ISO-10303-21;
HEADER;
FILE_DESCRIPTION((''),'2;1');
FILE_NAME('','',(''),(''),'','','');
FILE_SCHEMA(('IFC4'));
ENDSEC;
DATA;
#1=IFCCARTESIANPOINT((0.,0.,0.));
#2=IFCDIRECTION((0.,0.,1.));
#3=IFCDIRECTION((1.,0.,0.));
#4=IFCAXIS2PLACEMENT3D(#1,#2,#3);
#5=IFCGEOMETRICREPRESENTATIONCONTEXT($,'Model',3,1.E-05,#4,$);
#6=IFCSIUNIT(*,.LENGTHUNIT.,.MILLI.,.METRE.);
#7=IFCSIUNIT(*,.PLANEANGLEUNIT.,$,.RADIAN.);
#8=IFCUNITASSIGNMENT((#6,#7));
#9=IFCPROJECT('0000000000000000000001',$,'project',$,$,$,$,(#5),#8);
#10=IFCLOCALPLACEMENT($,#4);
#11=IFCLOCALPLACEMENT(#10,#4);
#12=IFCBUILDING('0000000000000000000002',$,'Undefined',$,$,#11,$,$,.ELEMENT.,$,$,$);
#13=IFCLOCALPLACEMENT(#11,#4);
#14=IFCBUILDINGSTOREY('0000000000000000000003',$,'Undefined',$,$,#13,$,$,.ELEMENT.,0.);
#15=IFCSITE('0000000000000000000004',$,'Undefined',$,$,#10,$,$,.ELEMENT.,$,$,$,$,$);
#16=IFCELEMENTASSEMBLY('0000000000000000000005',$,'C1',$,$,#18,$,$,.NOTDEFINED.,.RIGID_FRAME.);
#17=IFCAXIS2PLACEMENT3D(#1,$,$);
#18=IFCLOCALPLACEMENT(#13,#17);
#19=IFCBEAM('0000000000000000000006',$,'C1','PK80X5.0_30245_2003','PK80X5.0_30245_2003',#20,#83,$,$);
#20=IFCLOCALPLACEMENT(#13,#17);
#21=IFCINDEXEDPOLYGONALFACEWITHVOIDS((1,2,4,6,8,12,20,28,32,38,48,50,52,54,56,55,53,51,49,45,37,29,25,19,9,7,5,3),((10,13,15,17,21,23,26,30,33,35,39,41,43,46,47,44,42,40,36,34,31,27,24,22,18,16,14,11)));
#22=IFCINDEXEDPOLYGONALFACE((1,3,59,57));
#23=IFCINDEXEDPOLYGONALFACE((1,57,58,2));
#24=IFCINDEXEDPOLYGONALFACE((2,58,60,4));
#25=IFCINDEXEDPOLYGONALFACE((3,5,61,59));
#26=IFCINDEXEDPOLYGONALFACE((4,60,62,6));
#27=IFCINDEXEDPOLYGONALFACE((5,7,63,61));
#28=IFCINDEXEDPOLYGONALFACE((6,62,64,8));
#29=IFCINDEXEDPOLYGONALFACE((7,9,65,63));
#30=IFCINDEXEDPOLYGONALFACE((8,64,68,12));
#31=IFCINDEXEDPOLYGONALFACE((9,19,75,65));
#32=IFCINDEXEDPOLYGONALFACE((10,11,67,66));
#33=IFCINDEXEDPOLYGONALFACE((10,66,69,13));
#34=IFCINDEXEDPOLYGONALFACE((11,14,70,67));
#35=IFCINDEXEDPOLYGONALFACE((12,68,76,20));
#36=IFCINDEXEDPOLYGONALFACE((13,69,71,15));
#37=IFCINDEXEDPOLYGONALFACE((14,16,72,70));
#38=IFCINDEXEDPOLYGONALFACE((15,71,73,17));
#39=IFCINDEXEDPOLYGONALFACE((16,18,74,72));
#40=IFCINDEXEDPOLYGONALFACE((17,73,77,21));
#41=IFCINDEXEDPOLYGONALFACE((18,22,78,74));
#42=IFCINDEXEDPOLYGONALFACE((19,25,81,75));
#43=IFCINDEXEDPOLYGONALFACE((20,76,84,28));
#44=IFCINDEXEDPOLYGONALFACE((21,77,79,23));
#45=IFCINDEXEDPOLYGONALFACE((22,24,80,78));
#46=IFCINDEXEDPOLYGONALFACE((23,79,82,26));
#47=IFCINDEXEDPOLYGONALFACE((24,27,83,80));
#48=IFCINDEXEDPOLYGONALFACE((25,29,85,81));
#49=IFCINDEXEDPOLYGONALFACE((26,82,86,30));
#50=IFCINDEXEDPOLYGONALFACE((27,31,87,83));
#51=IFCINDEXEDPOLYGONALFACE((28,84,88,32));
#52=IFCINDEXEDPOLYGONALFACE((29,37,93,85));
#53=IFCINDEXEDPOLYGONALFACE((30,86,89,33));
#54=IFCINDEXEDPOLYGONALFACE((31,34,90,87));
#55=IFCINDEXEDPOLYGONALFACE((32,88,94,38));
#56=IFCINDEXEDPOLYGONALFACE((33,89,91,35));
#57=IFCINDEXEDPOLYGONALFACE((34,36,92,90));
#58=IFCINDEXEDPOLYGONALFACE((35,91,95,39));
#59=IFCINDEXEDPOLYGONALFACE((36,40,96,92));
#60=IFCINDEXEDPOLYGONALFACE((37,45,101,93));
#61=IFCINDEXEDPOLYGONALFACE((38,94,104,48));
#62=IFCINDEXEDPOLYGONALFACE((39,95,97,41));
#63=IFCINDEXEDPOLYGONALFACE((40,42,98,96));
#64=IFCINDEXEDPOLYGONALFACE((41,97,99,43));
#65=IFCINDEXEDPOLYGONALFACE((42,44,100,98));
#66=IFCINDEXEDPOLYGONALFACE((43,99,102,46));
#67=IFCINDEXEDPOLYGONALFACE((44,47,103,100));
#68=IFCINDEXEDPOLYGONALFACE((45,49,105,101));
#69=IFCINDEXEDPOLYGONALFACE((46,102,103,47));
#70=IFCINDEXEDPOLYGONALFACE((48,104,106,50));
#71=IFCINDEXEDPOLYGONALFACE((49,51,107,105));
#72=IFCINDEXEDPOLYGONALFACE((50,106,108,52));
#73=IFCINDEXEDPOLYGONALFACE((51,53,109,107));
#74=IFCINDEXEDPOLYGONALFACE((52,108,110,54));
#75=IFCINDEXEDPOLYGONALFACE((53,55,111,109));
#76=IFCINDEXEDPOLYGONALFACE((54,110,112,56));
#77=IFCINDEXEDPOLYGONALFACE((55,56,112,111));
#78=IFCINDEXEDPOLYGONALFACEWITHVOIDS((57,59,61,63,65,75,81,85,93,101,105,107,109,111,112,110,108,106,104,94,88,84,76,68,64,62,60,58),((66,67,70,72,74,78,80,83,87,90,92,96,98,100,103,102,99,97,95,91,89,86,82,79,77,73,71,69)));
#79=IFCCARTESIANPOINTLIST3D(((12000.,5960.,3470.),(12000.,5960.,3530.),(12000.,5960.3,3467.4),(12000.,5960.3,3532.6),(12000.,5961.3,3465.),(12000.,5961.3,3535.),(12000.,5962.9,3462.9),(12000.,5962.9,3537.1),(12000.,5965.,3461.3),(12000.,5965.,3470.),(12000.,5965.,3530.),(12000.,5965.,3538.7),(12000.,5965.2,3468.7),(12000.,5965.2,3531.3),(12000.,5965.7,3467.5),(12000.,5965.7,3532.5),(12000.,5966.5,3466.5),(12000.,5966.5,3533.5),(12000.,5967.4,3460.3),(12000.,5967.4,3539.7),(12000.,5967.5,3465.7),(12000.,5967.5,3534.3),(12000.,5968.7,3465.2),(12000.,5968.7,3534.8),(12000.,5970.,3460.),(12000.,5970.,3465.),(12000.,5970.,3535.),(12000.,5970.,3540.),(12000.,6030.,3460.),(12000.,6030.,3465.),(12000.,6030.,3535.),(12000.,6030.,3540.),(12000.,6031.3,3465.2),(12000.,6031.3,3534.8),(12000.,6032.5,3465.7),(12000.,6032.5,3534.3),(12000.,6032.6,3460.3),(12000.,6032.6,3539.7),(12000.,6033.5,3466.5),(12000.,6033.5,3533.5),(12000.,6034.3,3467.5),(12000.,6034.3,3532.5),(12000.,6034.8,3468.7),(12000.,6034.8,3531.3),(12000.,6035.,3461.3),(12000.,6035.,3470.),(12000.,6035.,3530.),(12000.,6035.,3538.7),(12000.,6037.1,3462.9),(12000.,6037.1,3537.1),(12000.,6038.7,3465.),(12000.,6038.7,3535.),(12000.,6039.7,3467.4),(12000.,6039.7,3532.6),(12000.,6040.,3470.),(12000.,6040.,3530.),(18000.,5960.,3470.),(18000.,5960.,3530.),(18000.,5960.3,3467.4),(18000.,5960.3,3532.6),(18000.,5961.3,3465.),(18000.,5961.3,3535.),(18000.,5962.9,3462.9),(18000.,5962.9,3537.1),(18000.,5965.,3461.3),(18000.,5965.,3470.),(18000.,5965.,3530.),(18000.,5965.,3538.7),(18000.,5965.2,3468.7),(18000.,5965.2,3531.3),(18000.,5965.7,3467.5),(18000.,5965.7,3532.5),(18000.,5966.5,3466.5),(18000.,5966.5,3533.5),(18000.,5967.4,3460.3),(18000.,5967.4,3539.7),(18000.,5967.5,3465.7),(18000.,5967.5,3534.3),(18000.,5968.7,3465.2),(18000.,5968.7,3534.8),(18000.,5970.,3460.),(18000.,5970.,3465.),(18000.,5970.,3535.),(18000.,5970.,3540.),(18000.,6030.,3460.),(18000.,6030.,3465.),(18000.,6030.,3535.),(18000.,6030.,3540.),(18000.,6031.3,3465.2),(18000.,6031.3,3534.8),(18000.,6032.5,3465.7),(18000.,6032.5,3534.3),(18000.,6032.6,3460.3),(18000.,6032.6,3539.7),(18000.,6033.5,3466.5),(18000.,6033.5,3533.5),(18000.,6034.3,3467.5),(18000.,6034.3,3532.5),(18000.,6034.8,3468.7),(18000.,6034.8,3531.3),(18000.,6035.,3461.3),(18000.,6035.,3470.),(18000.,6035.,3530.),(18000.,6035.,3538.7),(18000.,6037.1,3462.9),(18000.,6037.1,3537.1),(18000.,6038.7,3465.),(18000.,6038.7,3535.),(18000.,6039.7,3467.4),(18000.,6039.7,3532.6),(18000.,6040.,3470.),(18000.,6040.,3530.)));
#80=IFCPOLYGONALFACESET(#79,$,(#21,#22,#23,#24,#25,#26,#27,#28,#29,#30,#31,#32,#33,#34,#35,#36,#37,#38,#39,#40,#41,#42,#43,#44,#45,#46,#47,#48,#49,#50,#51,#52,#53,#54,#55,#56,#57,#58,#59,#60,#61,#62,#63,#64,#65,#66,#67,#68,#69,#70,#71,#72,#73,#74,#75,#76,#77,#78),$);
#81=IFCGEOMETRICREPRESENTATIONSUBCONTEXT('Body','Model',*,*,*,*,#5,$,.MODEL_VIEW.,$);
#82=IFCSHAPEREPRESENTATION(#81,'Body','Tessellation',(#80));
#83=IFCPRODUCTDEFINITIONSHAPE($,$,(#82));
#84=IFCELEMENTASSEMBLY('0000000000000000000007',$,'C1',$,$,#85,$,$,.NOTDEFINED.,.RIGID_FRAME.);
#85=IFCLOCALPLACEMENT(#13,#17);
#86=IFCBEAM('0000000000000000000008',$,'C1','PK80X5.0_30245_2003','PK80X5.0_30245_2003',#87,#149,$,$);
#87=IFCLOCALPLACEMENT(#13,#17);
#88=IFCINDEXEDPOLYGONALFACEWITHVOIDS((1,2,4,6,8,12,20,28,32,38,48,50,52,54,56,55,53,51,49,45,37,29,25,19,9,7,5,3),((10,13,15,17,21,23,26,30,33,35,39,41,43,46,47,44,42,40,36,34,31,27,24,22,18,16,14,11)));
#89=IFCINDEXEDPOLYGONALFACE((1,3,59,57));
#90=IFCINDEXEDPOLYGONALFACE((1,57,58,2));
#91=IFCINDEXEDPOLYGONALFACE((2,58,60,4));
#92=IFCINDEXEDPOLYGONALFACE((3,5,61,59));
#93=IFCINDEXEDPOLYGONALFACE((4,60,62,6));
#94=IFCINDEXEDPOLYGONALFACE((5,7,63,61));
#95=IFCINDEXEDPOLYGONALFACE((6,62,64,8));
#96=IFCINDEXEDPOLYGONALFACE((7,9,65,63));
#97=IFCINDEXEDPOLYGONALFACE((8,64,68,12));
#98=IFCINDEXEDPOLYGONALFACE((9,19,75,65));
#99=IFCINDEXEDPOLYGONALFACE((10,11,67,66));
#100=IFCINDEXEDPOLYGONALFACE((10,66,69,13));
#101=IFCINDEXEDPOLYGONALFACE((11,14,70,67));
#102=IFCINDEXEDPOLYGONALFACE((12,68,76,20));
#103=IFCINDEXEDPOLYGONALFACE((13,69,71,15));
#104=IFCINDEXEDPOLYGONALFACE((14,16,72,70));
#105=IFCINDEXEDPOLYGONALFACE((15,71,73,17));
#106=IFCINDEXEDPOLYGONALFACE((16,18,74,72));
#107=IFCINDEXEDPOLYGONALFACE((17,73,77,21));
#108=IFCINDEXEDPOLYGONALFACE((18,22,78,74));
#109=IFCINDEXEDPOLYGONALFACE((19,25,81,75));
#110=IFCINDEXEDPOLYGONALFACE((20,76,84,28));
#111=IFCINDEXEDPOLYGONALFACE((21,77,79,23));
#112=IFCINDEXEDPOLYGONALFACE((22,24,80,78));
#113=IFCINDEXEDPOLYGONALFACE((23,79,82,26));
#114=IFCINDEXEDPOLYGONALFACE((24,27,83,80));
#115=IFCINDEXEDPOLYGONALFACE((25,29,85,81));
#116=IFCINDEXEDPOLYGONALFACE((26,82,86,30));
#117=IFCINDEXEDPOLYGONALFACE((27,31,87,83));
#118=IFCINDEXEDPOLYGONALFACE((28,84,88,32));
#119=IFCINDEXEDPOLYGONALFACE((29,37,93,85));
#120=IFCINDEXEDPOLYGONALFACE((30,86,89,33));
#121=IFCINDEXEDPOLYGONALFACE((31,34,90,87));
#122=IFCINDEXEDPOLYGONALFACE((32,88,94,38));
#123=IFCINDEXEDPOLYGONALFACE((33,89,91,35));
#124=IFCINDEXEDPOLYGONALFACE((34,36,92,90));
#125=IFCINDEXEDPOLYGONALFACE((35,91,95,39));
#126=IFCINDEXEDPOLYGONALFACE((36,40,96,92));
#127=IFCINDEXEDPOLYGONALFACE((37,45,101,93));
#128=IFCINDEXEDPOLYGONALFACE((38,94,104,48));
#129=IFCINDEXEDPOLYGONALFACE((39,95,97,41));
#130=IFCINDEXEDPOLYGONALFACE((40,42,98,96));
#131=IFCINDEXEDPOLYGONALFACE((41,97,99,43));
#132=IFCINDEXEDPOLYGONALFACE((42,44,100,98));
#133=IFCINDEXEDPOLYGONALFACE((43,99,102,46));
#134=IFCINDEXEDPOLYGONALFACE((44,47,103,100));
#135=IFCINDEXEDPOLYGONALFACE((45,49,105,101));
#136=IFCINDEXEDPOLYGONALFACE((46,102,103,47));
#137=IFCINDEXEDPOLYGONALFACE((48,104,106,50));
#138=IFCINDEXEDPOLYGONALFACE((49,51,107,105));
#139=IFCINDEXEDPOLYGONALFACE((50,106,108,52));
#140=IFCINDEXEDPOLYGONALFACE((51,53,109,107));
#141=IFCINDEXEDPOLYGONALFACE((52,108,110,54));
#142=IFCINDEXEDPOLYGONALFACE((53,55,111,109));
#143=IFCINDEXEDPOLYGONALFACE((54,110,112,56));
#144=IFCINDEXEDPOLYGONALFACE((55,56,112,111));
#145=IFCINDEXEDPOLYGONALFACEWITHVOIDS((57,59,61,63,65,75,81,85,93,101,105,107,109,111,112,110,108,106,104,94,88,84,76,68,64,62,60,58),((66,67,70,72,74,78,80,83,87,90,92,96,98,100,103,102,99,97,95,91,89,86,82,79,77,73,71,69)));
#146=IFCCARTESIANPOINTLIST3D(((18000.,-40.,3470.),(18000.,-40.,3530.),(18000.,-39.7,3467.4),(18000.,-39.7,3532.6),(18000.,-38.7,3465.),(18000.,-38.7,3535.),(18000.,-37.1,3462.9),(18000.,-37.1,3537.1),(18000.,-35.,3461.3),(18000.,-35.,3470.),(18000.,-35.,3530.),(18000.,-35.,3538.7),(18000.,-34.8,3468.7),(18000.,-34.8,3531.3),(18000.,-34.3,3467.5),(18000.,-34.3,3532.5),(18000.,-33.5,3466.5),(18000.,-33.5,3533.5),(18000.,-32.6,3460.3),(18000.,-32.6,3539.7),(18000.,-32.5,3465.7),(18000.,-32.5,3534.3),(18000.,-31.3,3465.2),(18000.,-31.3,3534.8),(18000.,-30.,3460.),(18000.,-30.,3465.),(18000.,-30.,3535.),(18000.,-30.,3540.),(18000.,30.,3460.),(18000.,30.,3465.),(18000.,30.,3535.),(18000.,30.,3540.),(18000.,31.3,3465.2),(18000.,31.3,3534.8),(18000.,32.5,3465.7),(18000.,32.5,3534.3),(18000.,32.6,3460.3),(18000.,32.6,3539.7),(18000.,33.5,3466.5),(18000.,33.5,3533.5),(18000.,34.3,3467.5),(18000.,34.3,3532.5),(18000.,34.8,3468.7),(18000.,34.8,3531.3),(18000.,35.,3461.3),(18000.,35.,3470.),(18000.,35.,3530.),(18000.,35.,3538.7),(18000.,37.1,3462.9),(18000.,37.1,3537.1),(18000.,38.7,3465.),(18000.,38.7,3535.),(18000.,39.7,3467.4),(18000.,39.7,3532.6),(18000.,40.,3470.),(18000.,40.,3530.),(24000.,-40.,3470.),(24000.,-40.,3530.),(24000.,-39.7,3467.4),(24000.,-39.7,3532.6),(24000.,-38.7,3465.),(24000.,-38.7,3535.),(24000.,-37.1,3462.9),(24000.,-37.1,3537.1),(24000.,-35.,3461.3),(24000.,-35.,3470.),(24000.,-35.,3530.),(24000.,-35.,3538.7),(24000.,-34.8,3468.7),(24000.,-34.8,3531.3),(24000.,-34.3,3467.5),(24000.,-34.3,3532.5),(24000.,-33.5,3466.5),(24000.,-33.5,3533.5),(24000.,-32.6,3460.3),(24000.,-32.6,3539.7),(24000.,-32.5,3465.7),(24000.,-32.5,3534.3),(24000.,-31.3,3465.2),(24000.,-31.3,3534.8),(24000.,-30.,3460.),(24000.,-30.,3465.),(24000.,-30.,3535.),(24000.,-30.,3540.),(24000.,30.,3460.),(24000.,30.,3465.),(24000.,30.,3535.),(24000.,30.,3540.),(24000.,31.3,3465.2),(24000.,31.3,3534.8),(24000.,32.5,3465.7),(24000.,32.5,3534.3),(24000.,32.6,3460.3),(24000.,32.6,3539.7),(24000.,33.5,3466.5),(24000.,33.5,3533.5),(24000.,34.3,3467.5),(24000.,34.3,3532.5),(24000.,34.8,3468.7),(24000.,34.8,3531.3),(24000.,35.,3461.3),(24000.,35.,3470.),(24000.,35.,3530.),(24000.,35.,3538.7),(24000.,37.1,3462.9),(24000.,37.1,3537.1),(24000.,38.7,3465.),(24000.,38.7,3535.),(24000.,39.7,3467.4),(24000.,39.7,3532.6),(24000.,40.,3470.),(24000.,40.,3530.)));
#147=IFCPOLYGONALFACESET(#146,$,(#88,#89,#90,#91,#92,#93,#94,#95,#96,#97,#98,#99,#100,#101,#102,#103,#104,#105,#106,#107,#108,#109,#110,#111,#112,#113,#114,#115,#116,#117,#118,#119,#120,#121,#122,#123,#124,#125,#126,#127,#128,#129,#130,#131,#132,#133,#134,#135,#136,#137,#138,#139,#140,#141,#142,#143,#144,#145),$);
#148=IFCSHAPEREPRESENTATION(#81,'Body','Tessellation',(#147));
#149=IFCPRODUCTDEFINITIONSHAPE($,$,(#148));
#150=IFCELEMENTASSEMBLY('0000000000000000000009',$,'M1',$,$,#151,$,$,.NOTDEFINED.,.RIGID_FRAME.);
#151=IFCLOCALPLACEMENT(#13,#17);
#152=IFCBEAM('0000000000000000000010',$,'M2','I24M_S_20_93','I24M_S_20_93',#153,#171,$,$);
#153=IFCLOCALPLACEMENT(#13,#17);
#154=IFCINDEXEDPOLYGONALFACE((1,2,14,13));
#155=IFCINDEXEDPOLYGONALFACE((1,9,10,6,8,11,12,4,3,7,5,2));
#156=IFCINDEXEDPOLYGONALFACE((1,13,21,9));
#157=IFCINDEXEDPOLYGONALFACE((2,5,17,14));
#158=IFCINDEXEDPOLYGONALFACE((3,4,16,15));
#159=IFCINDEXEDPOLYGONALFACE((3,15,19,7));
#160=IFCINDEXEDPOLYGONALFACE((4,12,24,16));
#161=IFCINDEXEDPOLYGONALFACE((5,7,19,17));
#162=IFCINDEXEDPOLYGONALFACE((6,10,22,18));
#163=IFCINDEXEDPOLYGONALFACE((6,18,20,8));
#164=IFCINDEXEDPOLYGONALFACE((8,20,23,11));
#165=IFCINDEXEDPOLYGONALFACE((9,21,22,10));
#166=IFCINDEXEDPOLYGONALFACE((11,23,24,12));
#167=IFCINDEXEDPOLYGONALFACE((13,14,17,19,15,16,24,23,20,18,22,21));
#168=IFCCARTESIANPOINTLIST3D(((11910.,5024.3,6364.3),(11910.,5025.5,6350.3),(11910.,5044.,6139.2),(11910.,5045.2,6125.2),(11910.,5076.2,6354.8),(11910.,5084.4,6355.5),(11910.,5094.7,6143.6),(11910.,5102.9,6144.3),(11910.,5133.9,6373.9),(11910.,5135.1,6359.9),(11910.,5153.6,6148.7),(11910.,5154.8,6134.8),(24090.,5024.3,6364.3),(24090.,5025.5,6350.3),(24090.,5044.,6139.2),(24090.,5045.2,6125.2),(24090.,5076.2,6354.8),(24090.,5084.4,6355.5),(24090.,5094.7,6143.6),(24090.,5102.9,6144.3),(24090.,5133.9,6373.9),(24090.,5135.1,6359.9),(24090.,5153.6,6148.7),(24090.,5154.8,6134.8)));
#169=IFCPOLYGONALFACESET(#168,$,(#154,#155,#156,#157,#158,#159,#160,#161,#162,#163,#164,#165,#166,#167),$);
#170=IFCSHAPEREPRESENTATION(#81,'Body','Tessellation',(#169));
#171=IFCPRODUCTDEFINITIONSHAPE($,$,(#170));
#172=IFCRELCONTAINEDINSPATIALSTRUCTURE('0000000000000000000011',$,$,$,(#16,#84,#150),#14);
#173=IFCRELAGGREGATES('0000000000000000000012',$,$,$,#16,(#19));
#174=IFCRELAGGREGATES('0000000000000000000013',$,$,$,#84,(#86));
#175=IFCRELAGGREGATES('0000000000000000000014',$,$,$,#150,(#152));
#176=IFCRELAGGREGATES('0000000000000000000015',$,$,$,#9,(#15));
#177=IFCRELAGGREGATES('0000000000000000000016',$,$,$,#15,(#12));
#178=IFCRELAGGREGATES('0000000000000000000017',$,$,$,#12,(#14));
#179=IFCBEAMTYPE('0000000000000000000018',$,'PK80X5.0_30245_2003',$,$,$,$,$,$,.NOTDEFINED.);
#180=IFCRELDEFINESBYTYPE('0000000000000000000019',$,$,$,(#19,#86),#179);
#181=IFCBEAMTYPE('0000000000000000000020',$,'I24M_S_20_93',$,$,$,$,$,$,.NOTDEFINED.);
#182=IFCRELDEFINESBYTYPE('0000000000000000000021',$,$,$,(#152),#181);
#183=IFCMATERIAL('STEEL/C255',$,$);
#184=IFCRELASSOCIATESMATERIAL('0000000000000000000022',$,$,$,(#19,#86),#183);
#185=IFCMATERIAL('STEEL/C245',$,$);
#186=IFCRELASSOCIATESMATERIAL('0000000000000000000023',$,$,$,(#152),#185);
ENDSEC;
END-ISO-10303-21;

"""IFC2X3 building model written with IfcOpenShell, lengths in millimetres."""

from ifc_helpers import new_model, si_unit, frame, origin_with_axes, origin_2d_with_axis, place, context, subcontext, project, spatial, hollow_rectangle, i_section, extrude, material, type_object, element, aggregate, save


model = new_model("IFC2X3")

# Units and contexts
model_context = context("Model", 3, precision=1e-05, world=origin_with_axes())
body_context = subcontext(model_context, "Body", "Model", "MODEL_VIEW")
ifc_project = project(units=[si_unit("LENGTHUNIT", "METRE", prefix="MILLI"), si_unit("PLANEANGLEUNIT", "RADIAN")], contexts=[model_context])

# Site, building, storey
site_placement = place(None, origin_with_axes())
site = spatial("IfcSite", under=ifc_project, at=site_placement, Name="Undefined", CompositionType="ELEMENT")
building_placement = place(site_placement, origin_with_axes())
building = spatial("IfcBuilding", under=site, at=building_placement, Name="Undefined", CompositionType="ELEMENT")
storey_placement = place(building_placement, origin_with_axes())
storey = spatial("IfcBuildingStorey", under=building, at=storey_placement, Name="Undefined", CompositionType="ELEMENT", Elevation=0.0)

# Element assemblies, beams
ifc_material_1 = material(Name="STEEL/C255")
beam_type_1 = type_object("IfcBeamType", Name="PK80X5.0_30245_2003", PredefinedType="NOTDEFINED")
assembly_1_placement = place(storey_placement, origin_with_axes())
assembly_1 = element("IfcElementAssembly", 1, at=assembly_1_placement, inside=storey, Name="C1", AssemblyPlace="NOTDEFINED", PredefinedType="RIGID_FRAME")
beam_1_placement = place(assembly_1_placement, frame((12000.0, 6000.0, 3500.0), z_axis=(0.0, 0.0, -1.0), x_axis=(1.0, 0.0, 0.0)))
beam_1 = element("IfcBeam", 2, at=beam_1_placement, type_object=beam_type_1, material=ifc_material_1, Name="C1", Description="PK80X5.0_30245_2003", ObjectType="PK80X5.0_30245_2003", context=body_context, shape_type="SweptSolid", body=[
    extrude(hollow_rectangle(XDim=80.0, YDim=80.0, WallThickness=5.0, InnerFilletRadius=5.0, OuterFilletRadius=10.0, at=origin_2d_with_axis()), frame((6000.0, 0.0, 0.0), z_axis=(-1.0, 0.0, 0.0), x_axis=(0.0, -1.0, 0.0)), (0.0, 0.0, 1.0), 6000.0),
])
aggregate(assembly_1, [beam_1])
assembly_2_placement = place(storey_placement, origin_with_axes())
assembly_2 = element("IfcElementAssembly", 3, at=assembly_2_placement, inside=storey, Name="C1", AssemblyPlace="NOTDEFINED", PredefinedType="RIGID_FRAME")
beam_2_placement = place(assembly_2_placement, frame((18000.0, 0.0, 3500.0), z_axis=(0.0, 0.0, -1.0), x_axis=(1.0, 0.0, 0.0)))
beam_2 = element("IfcBeam", 4, at=beam_2_placement, type_object=beam_type_1, material=ifc_material_1, Name="C1", Description="PK80X5.0_30245_2003", ObjectType="PK80X5.0_30245_2003", context=body_context, shape_type="SweptSolid", body=[
    extrude(hollow_rectangle(XDim=80.0, YDim=80.0, WallThickness=5.0, InnerFilletRadius=5.0, OuterFilletRadius=10.0, at=origin_2d_with_axis()), frame((6000.0, 0.0, 0.0), z_axis=(-1.0, 0.0, 0.0), x_axis=(0.0, -1.0, 0.0)), (0.0, 0.0, 1.0), 6000.0),
])
aggregate(assembly_2, [beam_2])
assembly_3_placement = place(storey_placement, origin_with_axes())
assembly_3 = element("IfcElementAssembly", 5, at=assembly_3_placement, inside=storey, Name="M1", AssemblyPlace="NOTDEFINED", PredefinedType="RIGID_FRAME")
ifc_material_2 = material(Name="STEEL/C245")
beam_type_2 = type_object("IfcBeamType", Name="I24M_S_20_93", PredefinedType="NOTDEFINED")
beam_3_placement = place(assembly_3_placement, frame((11910.0, 5089.5, 6249.5), z_axis=(0.0, -0.087156, 0.996195), x_axis=(1.0, 0.0, 0.0)))
beam_3 = element("IfcBeam", 6, at=beam_3_placement, type_object=beam_type_2, material=ifc_material_2, Name="M2", Description="I24M_S_20_93", ObjectType="I24M_S_20_93", context=body_context, shape_type="SweptSolid", body=[
    extrude(i_section(OverallWidth=110.0, OverallDepth=240.0, WebThickness=8.2, FlangeThickness=14.0, at=origin_2d_with_axis()), frame((12180.0, 0.0, 0.0), z_axis=(-1.0, 0.0, 0.0), x_axis=(0.0, -1.0, 0.0)), (0.0, 0.0, 1.0), 12180.0),
])
aggregate(assembly_3, [beam_3])

save(model, "model.ifc")
